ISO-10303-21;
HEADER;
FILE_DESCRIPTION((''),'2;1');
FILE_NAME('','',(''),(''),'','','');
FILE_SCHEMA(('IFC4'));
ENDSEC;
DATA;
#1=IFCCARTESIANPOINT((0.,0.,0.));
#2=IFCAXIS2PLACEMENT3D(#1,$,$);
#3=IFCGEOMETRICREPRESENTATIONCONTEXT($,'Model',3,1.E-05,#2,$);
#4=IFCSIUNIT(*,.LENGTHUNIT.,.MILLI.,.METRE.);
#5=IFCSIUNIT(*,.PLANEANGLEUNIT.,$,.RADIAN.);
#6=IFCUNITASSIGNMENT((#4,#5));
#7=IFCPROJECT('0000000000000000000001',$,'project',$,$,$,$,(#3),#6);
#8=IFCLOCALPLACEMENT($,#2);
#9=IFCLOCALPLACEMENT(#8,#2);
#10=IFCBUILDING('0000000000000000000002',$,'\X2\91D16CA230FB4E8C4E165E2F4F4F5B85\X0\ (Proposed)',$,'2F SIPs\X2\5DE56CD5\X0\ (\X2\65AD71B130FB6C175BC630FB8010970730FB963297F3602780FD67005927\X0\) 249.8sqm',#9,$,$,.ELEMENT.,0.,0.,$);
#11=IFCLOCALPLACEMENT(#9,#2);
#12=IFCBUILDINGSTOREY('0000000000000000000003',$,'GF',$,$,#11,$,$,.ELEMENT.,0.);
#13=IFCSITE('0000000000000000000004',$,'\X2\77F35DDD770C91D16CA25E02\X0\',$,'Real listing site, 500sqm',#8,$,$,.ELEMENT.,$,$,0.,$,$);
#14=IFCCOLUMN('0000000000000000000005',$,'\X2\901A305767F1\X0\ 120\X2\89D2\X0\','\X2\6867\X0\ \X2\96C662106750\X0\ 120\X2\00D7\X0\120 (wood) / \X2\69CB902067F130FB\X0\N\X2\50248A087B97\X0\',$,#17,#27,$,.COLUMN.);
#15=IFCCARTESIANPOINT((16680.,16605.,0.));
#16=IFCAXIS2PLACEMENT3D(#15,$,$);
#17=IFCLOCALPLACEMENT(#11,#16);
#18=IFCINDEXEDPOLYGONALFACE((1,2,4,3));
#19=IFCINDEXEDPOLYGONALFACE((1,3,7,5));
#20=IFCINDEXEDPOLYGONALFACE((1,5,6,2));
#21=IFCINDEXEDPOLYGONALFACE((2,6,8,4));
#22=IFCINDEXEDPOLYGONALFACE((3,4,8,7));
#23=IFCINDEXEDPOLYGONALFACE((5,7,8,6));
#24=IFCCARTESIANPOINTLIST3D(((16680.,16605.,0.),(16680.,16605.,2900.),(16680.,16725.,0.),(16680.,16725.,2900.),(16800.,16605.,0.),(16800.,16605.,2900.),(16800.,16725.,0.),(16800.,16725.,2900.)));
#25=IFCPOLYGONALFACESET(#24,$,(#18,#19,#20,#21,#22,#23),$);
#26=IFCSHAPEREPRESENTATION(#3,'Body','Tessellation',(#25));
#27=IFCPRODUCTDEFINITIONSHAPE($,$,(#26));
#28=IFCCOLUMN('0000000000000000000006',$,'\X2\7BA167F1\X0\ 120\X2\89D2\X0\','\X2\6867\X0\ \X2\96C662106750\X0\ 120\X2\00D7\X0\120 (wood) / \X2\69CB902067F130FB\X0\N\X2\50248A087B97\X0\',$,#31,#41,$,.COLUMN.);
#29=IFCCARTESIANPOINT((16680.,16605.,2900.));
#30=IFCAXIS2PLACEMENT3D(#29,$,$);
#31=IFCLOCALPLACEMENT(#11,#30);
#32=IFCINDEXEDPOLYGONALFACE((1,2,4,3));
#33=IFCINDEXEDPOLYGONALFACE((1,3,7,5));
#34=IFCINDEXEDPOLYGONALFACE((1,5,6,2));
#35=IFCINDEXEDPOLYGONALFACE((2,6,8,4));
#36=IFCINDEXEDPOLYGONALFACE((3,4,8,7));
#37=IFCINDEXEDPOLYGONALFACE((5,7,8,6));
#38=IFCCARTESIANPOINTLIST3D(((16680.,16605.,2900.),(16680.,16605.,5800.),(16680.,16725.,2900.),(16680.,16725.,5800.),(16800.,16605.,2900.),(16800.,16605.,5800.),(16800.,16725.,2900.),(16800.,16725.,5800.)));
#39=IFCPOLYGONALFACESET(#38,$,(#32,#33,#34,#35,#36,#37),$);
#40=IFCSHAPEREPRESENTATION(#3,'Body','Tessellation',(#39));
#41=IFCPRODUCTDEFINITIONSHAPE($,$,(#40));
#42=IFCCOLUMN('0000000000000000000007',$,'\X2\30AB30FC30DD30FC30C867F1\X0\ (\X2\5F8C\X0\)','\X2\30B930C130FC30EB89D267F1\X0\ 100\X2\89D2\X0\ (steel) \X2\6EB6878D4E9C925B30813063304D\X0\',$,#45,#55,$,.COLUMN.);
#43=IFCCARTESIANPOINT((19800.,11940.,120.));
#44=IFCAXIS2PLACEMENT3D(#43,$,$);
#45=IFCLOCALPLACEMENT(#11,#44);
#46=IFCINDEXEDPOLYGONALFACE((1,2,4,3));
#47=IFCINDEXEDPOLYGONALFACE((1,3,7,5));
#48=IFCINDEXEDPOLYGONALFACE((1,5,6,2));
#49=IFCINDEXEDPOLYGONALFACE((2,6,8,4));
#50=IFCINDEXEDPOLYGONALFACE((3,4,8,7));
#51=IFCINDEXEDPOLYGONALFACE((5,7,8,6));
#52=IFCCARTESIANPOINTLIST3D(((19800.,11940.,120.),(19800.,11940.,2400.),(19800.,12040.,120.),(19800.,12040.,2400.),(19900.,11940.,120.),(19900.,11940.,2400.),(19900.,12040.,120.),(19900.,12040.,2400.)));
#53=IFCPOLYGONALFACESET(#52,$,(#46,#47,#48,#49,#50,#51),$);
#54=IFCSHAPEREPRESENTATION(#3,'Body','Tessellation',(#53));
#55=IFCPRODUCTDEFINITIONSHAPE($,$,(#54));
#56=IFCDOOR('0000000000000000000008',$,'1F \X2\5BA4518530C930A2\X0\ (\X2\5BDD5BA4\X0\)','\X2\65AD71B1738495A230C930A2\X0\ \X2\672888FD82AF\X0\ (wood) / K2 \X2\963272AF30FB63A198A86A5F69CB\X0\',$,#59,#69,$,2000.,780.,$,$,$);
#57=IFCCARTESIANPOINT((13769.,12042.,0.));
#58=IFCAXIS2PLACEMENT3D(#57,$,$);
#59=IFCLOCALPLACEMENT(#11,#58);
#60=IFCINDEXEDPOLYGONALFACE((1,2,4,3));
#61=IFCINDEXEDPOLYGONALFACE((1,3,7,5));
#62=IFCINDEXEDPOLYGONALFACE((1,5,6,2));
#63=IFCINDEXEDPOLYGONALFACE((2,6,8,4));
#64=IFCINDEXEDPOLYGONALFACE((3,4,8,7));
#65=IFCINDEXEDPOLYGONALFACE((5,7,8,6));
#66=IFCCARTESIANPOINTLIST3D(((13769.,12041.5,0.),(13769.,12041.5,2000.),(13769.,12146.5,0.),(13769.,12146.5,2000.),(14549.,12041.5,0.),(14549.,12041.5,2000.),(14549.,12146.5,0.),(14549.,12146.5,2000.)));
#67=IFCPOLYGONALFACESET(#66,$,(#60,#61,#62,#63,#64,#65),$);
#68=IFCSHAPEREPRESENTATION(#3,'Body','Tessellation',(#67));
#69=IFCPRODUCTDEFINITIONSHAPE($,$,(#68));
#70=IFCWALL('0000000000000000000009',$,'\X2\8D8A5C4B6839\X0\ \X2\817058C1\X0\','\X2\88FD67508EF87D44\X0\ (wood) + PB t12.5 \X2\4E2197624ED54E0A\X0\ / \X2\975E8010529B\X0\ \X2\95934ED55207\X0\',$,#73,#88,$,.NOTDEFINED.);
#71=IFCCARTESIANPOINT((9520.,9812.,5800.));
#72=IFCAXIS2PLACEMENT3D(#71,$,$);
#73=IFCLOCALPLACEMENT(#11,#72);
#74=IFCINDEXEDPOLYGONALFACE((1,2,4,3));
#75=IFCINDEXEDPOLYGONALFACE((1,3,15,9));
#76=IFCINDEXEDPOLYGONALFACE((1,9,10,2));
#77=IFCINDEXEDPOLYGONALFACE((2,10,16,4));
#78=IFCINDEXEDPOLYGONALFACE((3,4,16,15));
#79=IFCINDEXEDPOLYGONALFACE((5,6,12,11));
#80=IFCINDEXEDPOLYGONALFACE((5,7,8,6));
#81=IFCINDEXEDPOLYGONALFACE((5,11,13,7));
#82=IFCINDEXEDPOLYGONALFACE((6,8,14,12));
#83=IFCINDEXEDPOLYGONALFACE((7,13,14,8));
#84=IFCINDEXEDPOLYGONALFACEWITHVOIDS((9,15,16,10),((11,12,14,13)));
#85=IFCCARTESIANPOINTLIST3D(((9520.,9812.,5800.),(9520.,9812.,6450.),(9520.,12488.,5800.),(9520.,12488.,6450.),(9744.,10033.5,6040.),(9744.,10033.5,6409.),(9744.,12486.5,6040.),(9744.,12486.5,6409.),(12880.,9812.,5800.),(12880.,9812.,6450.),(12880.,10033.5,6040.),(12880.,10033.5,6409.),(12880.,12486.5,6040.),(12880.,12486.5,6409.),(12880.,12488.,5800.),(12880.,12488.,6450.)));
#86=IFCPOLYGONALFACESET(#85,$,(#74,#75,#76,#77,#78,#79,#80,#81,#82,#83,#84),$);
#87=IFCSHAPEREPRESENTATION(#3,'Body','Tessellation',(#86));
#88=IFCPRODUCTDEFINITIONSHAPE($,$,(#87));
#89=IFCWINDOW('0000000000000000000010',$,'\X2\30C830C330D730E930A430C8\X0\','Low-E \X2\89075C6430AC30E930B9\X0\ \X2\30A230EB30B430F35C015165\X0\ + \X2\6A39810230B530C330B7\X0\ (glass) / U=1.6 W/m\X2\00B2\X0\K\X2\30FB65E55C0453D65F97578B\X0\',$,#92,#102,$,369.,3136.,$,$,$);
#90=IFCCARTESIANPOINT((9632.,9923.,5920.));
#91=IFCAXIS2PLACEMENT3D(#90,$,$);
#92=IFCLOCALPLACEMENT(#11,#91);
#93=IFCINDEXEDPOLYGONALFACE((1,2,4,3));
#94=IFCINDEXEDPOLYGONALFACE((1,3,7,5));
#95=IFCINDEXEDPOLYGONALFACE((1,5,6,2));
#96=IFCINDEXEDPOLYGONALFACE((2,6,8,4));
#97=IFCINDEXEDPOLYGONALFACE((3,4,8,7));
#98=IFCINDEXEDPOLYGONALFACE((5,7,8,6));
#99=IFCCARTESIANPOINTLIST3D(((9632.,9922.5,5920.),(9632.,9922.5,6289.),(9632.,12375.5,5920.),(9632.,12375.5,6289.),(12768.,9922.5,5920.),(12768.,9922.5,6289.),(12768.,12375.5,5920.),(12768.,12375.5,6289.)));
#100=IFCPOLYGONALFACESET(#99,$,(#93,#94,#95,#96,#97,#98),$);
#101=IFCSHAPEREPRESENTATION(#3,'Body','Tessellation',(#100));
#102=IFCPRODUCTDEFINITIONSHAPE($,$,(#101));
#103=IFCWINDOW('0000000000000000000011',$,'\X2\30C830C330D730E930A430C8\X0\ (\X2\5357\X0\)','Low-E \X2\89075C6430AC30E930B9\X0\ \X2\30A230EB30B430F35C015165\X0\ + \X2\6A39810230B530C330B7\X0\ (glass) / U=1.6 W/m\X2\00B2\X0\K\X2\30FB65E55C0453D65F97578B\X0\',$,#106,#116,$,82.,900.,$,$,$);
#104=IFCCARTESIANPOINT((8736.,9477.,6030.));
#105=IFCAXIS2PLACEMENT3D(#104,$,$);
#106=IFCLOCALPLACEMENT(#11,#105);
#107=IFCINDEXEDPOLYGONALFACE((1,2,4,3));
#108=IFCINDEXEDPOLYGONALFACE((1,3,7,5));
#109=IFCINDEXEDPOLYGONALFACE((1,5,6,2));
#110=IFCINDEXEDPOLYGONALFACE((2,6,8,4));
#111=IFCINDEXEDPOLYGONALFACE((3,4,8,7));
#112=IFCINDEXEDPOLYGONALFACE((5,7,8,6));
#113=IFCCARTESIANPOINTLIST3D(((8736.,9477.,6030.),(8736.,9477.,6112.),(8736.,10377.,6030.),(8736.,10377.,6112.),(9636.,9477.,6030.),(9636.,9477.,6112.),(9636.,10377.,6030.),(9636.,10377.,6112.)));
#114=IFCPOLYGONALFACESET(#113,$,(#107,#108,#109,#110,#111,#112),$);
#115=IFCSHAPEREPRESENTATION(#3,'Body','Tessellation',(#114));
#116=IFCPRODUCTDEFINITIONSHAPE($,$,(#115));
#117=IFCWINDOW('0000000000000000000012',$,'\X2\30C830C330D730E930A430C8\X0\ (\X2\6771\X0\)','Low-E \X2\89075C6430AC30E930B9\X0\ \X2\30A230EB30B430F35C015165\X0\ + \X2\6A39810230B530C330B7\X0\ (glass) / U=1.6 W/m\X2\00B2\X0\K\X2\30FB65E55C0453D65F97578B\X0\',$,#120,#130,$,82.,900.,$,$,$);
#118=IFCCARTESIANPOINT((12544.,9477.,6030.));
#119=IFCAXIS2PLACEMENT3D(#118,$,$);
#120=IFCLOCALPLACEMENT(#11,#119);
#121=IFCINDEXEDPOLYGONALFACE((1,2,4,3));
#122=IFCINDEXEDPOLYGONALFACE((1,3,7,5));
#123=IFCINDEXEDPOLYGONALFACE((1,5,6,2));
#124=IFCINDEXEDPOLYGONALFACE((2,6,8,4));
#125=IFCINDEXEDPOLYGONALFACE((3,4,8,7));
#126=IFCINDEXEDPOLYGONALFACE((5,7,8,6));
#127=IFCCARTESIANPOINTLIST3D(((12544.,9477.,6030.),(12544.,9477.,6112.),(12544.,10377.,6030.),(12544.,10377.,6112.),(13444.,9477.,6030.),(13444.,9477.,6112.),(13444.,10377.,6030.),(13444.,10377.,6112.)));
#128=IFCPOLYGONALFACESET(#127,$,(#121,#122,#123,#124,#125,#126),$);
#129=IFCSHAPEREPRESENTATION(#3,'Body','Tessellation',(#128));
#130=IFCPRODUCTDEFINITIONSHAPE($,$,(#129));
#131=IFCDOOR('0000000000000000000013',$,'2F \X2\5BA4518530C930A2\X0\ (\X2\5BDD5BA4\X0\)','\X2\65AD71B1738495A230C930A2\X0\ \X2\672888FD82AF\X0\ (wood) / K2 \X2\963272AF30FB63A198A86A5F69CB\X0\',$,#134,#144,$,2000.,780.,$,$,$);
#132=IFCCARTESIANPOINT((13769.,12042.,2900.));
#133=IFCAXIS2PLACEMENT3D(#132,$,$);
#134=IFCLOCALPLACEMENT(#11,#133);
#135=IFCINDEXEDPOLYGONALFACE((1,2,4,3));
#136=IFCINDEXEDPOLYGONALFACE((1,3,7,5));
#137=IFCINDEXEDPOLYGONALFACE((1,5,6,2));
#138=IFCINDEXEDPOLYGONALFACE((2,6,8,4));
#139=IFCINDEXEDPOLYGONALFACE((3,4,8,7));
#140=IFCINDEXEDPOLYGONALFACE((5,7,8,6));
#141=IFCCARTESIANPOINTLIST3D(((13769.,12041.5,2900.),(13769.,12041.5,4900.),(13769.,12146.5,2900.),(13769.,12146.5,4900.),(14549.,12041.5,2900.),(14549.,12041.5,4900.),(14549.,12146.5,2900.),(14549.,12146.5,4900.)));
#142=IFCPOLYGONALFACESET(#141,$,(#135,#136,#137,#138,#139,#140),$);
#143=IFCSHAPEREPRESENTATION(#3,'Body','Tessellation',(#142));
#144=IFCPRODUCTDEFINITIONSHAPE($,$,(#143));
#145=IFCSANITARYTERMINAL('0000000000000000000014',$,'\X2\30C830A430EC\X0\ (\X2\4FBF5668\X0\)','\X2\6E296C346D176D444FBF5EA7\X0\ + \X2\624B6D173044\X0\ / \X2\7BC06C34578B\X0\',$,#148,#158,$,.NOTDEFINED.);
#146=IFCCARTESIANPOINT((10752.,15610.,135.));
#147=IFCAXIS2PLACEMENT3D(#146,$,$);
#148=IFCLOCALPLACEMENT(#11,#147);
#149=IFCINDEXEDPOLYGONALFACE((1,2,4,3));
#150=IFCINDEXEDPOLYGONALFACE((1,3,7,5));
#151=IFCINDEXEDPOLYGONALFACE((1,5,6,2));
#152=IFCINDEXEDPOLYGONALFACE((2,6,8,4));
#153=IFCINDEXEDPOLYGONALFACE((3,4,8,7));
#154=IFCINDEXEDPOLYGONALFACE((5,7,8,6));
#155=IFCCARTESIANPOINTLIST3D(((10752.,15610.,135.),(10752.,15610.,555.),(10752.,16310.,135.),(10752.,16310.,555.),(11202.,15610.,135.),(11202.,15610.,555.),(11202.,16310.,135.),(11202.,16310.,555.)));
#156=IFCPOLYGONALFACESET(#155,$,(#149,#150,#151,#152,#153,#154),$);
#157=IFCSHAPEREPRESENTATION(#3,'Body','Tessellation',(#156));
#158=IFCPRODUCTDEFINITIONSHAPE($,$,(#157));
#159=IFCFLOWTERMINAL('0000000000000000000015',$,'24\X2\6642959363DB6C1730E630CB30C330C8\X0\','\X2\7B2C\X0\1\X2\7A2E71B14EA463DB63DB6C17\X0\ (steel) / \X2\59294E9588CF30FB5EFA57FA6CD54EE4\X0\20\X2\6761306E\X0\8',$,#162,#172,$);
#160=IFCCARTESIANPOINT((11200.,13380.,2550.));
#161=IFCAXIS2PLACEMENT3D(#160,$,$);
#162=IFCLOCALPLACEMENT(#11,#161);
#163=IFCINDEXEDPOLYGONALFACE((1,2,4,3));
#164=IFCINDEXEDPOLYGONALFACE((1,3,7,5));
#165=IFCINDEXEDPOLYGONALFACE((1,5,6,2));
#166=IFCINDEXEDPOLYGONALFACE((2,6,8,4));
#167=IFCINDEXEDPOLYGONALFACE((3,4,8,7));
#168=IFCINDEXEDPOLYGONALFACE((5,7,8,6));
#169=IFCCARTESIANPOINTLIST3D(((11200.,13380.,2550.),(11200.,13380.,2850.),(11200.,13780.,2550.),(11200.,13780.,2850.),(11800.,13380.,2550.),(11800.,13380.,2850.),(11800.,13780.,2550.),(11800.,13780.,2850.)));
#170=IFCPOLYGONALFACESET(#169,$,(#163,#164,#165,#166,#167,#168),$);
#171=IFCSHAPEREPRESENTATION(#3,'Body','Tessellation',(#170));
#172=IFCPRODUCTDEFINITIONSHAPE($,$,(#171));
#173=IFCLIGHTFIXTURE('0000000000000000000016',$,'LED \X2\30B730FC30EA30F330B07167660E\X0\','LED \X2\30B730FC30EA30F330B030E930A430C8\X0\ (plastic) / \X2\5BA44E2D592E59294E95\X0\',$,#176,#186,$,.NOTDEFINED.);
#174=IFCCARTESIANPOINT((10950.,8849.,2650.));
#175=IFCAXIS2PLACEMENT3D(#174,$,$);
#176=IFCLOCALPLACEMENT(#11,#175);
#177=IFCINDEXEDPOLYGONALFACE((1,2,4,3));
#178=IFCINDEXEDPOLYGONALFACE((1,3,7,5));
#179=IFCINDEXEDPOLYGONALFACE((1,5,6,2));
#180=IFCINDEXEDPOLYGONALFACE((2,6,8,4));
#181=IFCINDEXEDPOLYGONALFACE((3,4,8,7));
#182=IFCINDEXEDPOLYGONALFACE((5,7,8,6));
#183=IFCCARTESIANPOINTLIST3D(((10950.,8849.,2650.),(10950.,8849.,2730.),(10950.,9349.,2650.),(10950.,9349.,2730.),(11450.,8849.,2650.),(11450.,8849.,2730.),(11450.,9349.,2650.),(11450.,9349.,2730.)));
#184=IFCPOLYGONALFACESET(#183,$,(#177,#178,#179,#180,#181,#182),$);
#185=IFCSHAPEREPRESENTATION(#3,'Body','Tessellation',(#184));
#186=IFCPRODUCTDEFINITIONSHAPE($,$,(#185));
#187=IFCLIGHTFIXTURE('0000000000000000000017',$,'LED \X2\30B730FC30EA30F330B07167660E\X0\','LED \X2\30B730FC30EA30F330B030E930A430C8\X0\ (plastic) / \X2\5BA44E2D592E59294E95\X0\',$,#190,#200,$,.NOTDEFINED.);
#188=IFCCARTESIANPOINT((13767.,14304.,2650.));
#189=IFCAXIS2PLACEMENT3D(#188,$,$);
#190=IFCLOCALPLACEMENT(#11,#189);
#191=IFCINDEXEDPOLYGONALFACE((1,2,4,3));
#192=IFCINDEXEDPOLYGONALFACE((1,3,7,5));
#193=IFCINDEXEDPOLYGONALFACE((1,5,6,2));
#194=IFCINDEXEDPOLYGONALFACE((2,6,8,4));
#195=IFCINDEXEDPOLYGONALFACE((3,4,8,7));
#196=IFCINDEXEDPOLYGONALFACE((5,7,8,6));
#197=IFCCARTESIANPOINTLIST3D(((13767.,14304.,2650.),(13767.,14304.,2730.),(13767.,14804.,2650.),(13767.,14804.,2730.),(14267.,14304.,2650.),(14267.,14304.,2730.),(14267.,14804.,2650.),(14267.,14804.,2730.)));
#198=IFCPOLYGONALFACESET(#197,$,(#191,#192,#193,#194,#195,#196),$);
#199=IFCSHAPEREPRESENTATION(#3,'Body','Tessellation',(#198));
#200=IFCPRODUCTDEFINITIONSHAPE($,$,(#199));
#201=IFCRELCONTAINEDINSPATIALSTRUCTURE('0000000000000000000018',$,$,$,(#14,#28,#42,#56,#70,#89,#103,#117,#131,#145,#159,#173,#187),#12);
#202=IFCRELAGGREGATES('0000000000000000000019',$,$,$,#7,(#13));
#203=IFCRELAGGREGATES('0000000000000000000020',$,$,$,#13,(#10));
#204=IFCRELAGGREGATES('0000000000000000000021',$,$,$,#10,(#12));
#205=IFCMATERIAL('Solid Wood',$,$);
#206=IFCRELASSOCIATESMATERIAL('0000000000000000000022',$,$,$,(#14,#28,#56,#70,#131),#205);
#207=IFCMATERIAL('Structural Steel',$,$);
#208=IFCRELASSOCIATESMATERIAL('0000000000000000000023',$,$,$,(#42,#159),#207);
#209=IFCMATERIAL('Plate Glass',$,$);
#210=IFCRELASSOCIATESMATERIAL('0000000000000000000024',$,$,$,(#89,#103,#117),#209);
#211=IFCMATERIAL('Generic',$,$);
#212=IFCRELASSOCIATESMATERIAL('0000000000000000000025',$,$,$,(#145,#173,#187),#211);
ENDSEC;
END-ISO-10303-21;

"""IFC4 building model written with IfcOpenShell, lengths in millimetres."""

from ifc_helpers import new_model, si_unit, frame, frame_2d, origin, place, context, project, spatial, rectangle, extrude, material, element, fill, save


model = new_model("IFC4")

# Units and contexts
model_context = context("Model", 3, precision=1e-05, world=origin())
ifc_project = project(units=[si_unit("LENGTHUNIT", "METRE", prefix="MILLI"), si_unit("PLANEANGLEUNIT", "RADIAN")], contexts=[model_context])

# Site, building, storey
site_placement = place(None, origin())
site = spatial("IfcSite", under=ifc_project, at=site_placement, Name="石川県金沢市", ObjectType="Real listing site, 500sqm", CompositionType="ELEMENT", RefElevation=0.0)
building_placement = place(site_placement, origin())
building = spatial("IfcBuilding", under=site, at=building_placement, Name="金沢・二世帯住宅 (Proposed)", ObjectType="2F SIPs工法 (断熱・気密・耐震・防音性能最大) 249.8sqm", CompositionType="ELEMENT", ElevationOfRefHeight=0.0, ElevationOfTerrain=0.0)
storey_placement = place(building_placement, origin())
storey = spatial("IfcBuildingStorey", under=building, at=storey_placement, Name="GF", CompositionType="ELEMENT", Elevation=0.0)

# Columns
ifc_material_1 = material(Name="Solid Wood")
column_1_placement = place(storey_placement, frame((16680.0, 16605.0, 0.0)))
element("IfcColumn", 1, at=column_1_placement, inside=storey, material=ifc_material_1, Name="通し柱 120角", Description="桧 集成材 120×120 (wood) / 構造柱・N値計算", PredefinedType="COLUMN", context=model_context, shape_type="SweptSolid", body=[
    extrude(rectangle(XDim=120.0, YDim=120.0, at=frame_2d((60.0, 60.0))), frame((16680.0, 16605.0, 0.0)), (0.0, 0.0, 1.0), 2900.0),
])
column_2_placement = place(storey_placement, frame((16680.0, 16605.0, 2900.0)))
element("IfcColumn", 2, at=column_2_placement, inside=storey, material=ifc_material_1, Name="管柱 120角", Description="桧 集成材 120×120 (wood) / 構造柱・N値計算", PredefinedType="COLUMN", context=model_context, shape_type="SweptSolid", body=[
    extrude(rectangle(XDim=120.0, YDim=120.0, at=frame_2d((60.0, 60.0))), frame((16680.0, 16605.0, 2900.0)), (0.0, 0.0, 1.0), 2900.0),
])
ifc_material_2 = material(Name="Structural Steel")
column_3_placement = place(storey_placement, frame((19800.0, 11940.0, 120.0)))
element("IfcColumn", 3, at=column_3_placement, inside=storey, material=ifc_material_2, Name="カーポート柱 (後)", Description="スチール角柱 100角 (steel) 溶融亜鉛めっき", PredefinedType="COLUMN", context=model_context, shape_type="SweptSolid", body=[
    extrude(rectangle(XDim=100.0, YDim=100.0, at=frame_2d((50.0, 50.0))), frame((19800.0, 11940.0, 120.0)), (0.0, 0.0, 1.0), 2280.0),
])

# Door
door_1_placement = place(storey_placement, frame((13769.0, 12042.0, 0.0)))
element("IfcDoor", 4, at=door_1_placement, inside=storey, material=ifc_material_1, Name="1F 室内ドア (寝室)", Description="断熱玄関ドア 木製芯 (wood) / K2 防犯・採風機構", OverallHeight=2000.0, OverallWidth=780.0, context=model_context, shape_type="SweptSolid", body=[
    extrude(rectangle(XDim=780.0, YDim=105.0, at=frame_2d((390.0, 52.0))), frame((13769.0, 12042.0, 0.0)), (0.0, 0.0, 1.0), 2000.0),
])

# Wall, openings, windows
wall_1_placement = place(storey_placement, frame((9520.0, 9812.0, 5800.0)))
wall_1 = element("IfcWall", 5, at=wall_1_placement, inside=storey, material=ifc_material_1, Name="越屋根 腰壁", Description="製材軸組 (wood) + PB t12.5 両面仕上 / 非耐力 間仕切", PredefinedType="NOTDEFINED", context=model_context, shape_type="SweptSolid", body=[
    extrude(rectangle(XDim=3360.0, YDim=2676.0, at=frame_2d((1680.0, 1338.0))), frame((9520.0, 9812.0, 5800.0)), (0.0, 0.0, 1.0), 650.0),
])
opening_1_placement = place(storey_placement, frame((9632.0, 9923.0, 5920.0)))
opening_1 = element("IfcOpeningElement", 6, at=opening_1_placement, cuts=wall_1, PredefinedType="NOTDEFINED", context=model_context, shape_type="SweptSolid", body=[
    extrude(rectangle(XDim=3136.0, YDim=2453.0, at=frame_2d((1568.0, 1226.0))), frame((9632.0, 9923.0, 5920.0)), (0.0, 0.0, 1.0), 369.0),
])
opening_2_placement = place(storey_placement, frame((8736.0, 9477.0, 6030.0)))
opening_2 = element("IfcOpeningElement", 7, at=opening_2_placement, cuts=wall_1, PredefinedType="NOTDEFINED", context=model_context, shape_type="SweptSolid", body=[
    extrude(rectangle(XDim=900.0, YDim=900.0, at=frame_2d((450.0, 450.0))), frame((8736.0, 9477.0, 6030.0)), (0.0, 0.0, 1.0), 82.0),
])
opening_3_placement = place(storey_placement, frame((12544.0, 9477.0, 6030.0)))
opening_3 = element("IfcOpeningElement", 8, at=opening_3_placement, cuts=wall_1, PredefinedType="NOTDEFINED", context=model_context, shape_type="SweptSolid", body=[
    extrude(rectangle(XDim=900.0, YDim=900.0, at=frame_2d((450.0, 450.0))), frame((12544.0, 9477.0, 6030.0)), (0.0, 0.0, 1.0), 82.0),
])
ifc_material_3 = material(Name="Plate Glass")
window_1_placement = place(storey_placement, frame((9632.0, 9923.0, 5920.0)))
window_1 = element("IfcWindow", 9, at=window_1_placement, inside=storey, material=ifc_material_3, Name="トップライト", Description="Low-E 複層ガラス アルゴン封入 + 樹脂サッシ (glass) / U=1.6 W/m²K・日射取得型", OverallHeight=369.0, OverallWidth=3136.0, context=model_context, shape_type="SweptSolid", body=[
    extrude(rectangle(XDim=3136.0, YDim=2453.0, at=frame_2d((1568.0, 1226.0))), frame((9632.0, 9923.0, 5920.0)), (0.0, 0.0, 1.0), 369.0),
])
fill(opening_1, window_1)
window_2_placement = place(storey_placement, frame((8736.0, 9477.0, 6030.0)))
window_2 = element("IfcWindow", 10, at=window_2_placement, inside=storey, material=ifc_material_3, Name="トップライト (南)", Description="Low-E 複層ガラス アルゴン封入 + 樹脂サッシ (glass) / U=1.6 W/m²K・日射取得型", OverallHeight=82.0, OverallWidth=900.0, context=model_context, shape_type="SweptSolid", body=[
    extrude(rectangle(XDim=900.0, YDim=900.0, at=frame_2d((450.0, 450.0))), frame((8736.0, 9477.0, 6030.0)), (0.0, 0.0, 1.0), 82.0),
])
fill(opening_2, window_2)
window_3_placement = place(storey_placement, frame((12544.0, 9477.0, 6030.0)))
window_3 = element("IfcWindow", 11, at=window_3_placement, inside=storey, material=ifc_material_3, Name="トップライト (東)", Description="Low-E 複層ガラス アルゴン封入 + 樹脂サッシ (glass) / U=1.6 W/m²K・日射取得型", OverallHeight=82.0, OverallWidth=900.0, context=model_context, shape_type="SweptSolid", body=[
    extrude(rectangle(XDim=900.0, YDim=900.0, at=frame_2d((450.0, 450.0))), frame((12544.0, 9477.0, 6030.0)), (0.0, 0.0, 1.0), 82.0),
])
fill(opening_3, window_3)

# Door
door_2_placement = place(storey_placement, frame((13769.0, 12042.0, 2900.0)))
element("IfcDoor", 12, at=door_2_placement, inside=storey, material=ifc_material_1, Name="2F 室内ドア (寝室)", Description="断熱玄関ドア 木製芯 (wood) / K2 防犯・採風機構", OverallHeight=2000.0, OverallWidth=780.0, context=model_context, shape_type="SweptSolid", body=[
    extrude(rectangle(XDim=780.0, YDim=105.0, at=frame_2d((390.0, 52.0))), frame((13769.0, 12042.0, 2900.0)), (0.0, 0.0, 1.0), 2000.0),
])

# Sanitary terminal
ifc_material_4 = material(Name="Generic")
sanitary_terminal_placement = place(storey_placement, frame((10752.0, 15610.0, 135.0)))
element("IfcSanitaryTerminal", 13, at=sanitary_terminal_placement, inside=storey, material=ifc_material_4, Name="トイレ (便器)", Description="温水洗浄便座 + 手洗い / 節水型", PredefinedType="NOTDEFINED", context=model_context, shape_type="SweptSolid", body=[
    extrude(rectangle(XDim=450.0, YDim=700.0, at=frame_2d((225.0, 350.0))), frame((10752.0, 15610.0, 135.0)), (0.0, 0.0, 1.0), 420.0),
])

# Flow terminal
flow_terminal_placement = place(storey_placement, frame((11200.0, 13380.0, 2550.0)))
element("IfcFlowTerminal", 14, at=flow_terminal_placement, inside=storey, material=ifc_material_2, Name="24時間換気ユニット", Description="第1種熱交換換気 (steel) / 天井裏・建基法令20条の8", context=model_context, shape_type="SweptSolid", body=[
    extrude(rectangle(XDim=600.0, YDim=400.0, at=frame_2d((300.0, 200.0))), frame((11200.0, 13380.0, 2550.0)), (0.0, 0.0, 1.0), 300.0),
])

# Light fixtures
light_fixture_1_placement = place(storey_placement, frame((10950.0, 8849.0, 2650.0)))
element("IfcLightFixture", 15, at=light_fixture_1_placement, inside=storey, material=ifc_material_4, Name="LED シーリング照明", Description="LED シーリングライト (plastic) / 室中央天井", PredefinedType="NOTDEFINED", context=model_context, shape_type="SweptSolid", body=[
    extrude(rectangle(XDim=500.0, YDim=500.0, at=frame_2d((250.0, 250.0))), frame((10950.0, 8849.0, 2650.0)), (0.0, 0.0, 1.0), 80.0),
])
light_fixture_2_placement = place(storey_placement, frame((13767.0, 14304.0, 2650.0)))
element("IfcLightFixture", 16, at=light_fixture_2_placement, inside=storey, material=ifc_material_4, Name="LED シーリング照明", Description="LED シーリングライト (plastic) / 室中央天井", PredefinedType="NOTDEFINED", context=model_context, shape_type="SweptSolid", body=[
    extrude(rectangle(XDim=500.0, YDim=500.0, at=frame_2d((250.0, 250.0))), frame((13767.0, 14304.0, 2650.0)), (0.0, 0.0, 1.0), 80.0),
])

save(model, "model.ifc")
